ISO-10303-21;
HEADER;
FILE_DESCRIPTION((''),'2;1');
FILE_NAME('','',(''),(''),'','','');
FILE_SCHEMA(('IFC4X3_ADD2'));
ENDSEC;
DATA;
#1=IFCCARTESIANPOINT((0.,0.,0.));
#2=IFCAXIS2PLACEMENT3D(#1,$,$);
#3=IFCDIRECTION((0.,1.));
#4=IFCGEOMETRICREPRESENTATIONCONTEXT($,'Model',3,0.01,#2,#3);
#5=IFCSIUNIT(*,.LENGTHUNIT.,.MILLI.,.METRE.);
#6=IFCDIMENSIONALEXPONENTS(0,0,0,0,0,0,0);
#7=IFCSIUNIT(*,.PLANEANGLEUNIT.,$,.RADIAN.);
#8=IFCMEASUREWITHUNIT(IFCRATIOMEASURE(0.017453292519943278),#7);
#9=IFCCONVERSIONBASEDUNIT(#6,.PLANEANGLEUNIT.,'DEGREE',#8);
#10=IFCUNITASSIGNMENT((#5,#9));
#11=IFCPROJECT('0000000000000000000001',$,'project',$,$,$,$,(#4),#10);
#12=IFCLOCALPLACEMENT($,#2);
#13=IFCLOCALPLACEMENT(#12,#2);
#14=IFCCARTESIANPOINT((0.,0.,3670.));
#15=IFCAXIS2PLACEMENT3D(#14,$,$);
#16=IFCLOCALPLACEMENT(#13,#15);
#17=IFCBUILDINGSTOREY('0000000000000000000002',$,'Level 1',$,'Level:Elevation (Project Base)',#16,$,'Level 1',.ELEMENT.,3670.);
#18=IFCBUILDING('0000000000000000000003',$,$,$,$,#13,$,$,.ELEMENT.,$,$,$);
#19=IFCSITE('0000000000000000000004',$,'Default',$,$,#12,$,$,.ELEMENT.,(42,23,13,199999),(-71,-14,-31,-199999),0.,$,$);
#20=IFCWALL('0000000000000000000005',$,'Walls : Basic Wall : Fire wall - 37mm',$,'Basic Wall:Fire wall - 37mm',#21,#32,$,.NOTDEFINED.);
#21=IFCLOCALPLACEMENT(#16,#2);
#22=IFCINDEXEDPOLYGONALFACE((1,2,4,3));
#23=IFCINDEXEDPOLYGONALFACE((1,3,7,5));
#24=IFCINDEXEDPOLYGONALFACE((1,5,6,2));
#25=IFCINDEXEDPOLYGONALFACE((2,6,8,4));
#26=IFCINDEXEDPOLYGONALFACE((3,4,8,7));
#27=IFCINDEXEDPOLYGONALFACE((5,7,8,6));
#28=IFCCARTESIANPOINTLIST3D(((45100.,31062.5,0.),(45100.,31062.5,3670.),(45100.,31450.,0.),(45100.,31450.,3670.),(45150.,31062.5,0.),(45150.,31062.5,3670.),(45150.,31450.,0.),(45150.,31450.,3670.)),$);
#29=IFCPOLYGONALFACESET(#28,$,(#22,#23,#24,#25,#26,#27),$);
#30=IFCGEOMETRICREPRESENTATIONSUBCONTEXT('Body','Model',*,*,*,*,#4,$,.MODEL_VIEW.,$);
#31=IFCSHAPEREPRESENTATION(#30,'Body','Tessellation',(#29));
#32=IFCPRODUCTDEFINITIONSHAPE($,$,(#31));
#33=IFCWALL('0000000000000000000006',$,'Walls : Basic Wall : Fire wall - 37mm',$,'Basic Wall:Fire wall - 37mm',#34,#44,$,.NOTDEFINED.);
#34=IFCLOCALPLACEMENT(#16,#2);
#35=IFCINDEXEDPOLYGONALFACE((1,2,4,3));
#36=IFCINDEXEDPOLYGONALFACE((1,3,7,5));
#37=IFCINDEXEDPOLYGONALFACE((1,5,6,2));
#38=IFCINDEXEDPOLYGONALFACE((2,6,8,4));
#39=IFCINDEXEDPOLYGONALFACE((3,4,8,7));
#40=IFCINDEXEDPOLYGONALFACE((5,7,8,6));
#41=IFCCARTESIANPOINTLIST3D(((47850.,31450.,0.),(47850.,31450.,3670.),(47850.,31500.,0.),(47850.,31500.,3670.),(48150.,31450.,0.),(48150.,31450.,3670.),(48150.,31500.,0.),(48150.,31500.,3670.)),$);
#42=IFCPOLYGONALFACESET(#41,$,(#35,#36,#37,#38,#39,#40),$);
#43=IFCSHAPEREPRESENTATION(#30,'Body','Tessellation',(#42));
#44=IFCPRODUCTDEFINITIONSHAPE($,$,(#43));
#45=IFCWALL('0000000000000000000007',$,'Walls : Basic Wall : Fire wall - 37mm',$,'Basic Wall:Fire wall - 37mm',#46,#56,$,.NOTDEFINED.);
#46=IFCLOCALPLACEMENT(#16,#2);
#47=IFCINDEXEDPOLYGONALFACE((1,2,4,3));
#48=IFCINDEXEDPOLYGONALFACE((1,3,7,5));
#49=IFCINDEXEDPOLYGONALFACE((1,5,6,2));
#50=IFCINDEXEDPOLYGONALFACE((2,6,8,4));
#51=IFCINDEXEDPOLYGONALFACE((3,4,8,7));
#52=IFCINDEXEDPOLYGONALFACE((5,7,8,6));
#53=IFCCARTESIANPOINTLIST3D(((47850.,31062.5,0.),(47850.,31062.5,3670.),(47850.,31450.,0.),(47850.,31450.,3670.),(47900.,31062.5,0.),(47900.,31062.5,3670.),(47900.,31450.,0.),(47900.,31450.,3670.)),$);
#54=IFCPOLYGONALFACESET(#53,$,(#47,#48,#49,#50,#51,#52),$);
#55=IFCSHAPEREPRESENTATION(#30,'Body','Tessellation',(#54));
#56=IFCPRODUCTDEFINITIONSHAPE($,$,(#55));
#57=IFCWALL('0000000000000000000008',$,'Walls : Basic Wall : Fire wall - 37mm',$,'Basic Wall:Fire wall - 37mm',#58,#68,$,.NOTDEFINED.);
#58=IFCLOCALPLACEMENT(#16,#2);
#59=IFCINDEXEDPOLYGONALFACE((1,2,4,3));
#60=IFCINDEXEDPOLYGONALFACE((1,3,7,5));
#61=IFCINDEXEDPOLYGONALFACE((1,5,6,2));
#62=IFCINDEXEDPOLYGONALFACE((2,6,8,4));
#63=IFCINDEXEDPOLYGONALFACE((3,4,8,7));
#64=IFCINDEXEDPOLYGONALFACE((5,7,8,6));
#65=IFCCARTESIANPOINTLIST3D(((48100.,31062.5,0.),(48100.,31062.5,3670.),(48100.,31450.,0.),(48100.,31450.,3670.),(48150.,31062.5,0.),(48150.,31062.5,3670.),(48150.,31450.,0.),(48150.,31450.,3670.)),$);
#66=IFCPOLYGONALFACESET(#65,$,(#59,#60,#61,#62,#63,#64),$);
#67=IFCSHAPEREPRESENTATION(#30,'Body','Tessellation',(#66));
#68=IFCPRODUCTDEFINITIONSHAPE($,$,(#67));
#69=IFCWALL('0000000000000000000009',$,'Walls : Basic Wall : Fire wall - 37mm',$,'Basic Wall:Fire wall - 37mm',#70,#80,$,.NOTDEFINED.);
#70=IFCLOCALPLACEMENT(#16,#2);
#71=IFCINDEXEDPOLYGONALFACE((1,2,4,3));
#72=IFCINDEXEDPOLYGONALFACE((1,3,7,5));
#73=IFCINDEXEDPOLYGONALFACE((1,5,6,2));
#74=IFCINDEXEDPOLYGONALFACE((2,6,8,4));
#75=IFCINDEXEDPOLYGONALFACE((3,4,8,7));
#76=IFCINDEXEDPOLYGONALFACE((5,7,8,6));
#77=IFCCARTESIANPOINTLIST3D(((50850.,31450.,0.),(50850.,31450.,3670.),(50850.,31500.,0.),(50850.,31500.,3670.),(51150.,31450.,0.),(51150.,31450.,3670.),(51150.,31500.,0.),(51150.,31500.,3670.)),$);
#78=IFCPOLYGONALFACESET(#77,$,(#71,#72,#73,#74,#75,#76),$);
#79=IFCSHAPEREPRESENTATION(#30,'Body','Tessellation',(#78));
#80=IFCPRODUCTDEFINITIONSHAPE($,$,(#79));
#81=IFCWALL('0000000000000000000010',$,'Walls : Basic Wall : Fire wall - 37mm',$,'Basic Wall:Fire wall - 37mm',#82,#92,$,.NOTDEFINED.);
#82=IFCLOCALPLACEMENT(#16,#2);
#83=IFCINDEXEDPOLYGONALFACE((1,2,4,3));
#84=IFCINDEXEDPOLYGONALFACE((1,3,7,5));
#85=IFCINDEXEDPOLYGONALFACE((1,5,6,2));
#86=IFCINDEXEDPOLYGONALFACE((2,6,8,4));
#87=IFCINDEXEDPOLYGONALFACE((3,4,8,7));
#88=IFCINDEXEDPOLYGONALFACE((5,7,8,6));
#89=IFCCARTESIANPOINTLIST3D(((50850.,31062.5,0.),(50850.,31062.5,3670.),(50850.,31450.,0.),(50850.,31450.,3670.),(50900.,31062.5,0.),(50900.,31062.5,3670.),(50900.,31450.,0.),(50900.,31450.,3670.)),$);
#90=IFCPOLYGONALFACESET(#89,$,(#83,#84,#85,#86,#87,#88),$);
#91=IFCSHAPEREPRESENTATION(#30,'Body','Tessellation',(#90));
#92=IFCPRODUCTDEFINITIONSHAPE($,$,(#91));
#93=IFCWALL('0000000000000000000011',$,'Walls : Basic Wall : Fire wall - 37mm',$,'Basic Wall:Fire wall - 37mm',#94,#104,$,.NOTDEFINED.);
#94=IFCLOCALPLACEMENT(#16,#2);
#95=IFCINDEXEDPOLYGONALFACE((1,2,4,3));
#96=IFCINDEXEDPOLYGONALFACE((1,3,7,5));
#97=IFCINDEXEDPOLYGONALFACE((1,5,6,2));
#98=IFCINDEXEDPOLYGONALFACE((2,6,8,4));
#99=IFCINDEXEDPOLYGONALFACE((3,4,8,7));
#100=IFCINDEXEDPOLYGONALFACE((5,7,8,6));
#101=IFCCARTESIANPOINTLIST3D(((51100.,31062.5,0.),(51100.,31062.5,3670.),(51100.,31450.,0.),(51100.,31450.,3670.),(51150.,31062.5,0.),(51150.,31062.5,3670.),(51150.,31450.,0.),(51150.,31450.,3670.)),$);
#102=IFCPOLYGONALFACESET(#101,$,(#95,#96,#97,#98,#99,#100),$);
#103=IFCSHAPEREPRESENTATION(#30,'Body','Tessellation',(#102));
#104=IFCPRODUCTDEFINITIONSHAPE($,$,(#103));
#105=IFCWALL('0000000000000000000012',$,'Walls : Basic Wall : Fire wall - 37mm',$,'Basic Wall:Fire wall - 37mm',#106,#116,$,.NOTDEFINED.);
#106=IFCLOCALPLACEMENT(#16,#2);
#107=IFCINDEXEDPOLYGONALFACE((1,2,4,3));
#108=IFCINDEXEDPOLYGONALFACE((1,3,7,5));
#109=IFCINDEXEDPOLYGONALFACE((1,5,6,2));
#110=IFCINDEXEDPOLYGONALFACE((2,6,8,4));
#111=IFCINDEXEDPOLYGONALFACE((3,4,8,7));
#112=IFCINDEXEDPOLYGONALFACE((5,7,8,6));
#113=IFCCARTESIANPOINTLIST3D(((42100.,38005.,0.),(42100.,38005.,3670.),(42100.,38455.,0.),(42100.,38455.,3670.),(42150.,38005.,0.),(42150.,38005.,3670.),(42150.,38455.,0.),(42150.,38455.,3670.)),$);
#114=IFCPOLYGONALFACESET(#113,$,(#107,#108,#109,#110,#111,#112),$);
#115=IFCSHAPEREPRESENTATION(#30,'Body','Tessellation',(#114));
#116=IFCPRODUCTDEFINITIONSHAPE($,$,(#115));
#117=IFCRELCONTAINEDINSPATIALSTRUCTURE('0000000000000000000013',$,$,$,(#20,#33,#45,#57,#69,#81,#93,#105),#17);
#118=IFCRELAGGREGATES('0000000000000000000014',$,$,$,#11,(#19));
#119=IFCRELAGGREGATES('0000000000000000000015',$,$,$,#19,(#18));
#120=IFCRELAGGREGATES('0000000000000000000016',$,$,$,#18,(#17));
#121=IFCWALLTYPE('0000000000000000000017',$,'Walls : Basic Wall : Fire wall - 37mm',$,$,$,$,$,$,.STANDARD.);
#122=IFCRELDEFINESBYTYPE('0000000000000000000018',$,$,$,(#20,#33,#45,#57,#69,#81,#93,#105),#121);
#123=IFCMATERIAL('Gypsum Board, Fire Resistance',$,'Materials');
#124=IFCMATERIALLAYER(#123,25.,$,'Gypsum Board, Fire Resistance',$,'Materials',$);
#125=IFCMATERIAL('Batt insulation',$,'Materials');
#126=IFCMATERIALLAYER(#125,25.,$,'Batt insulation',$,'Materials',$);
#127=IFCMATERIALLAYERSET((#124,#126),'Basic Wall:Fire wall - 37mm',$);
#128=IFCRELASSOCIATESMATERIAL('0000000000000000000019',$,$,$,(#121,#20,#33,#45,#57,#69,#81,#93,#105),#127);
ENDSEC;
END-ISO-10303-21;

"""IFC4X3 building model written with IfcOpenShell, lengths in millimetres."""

from ifc_helpers import new_model, entity, si_unit, converted_unit, direction, frame, frame_2d, origin, place, context, subcontext, project, spatial, rectangle, extrude, material, layer, layer_set, type_object, element, save


model = new_model("IFC4X3")

# Units and contexts
model_context = context("Model", 3, precision=0.01, world=origin(), true_north=direction((0.0, 1.0)))
body_context = subcontext(model_context, "Body", "Model", "MODEL_VIEW")
ifc_project = project(units=[si_unit("LENGTHUNIT", "METRE", prefix="MILLI"), converted_unit("PLANEANGLEUNIT", "DEGREE", entity("IfcRatioMeasure", 0.017453292519943278), si_unit("PLANEANGLEUNIT", "RADIAN"), dimensions=[0, 0, 0, 0, 0, 0, 0])], contexts=[model_context])

# Site, building, storey
site_placement = place(None, origin())
site = spatial("IfcSite", under=ifc_project, at=site_placement, Name="Default", CompositionType="ELEMENT", RefLatitude=(42, 23, 13, 199999), RefLongitude=(-71, -14, -31, -199999), RefElevation=0.0)
building_placement = place(site_placement, origin())
building = spatial("IfcBuilding", under=site, at=building_placement, CompositionType="ELEMENT")
storey_placement = place(building_placement, frame((0.0, 0.0, 3670.0)))
storey = spatial("IfcBuildingStorey", under=building, at=storey_placement, Name="Level 1", ObjectType="Level:Elevation (Project Base)", LongName="Level 1", CompositionType="ELEMENT", Elevation=3670.0)

# Walls
ifc_material_1 = material(Name="Gypsum Board, Fire Resistance", Category="Materials")
ifc_layer_1 = layer(ifc_material_1, 25.0, Name="Gypsum Board, Fire Resistance", Category="Materials")
ifc_material_2 = material(Name="Batt insulation", Category="Materials")
ifc_layer_2 = layer(ifc_material_2, 25.0, Name="Batt insulation", Category="Materials")
ifc_layer_set = layer_set([ifc_layer_1, ifc_layer_2], Name="Basic Wall:Fire wall - 37mm")
wall_type = type_object("IfcWallType", Name="Walls : Basic Wall : Fire wall - 37mm", PredefinedType="STANDARD", material=ifc_layer_set)
for number, where, z_axis, x_axis, name in (
    (1, (45125.0, 31450.0, 0.0), (0.0, 0.0, 1.0), (0.0, -1.0, 0.0), "Walls : Basic Wall : Fire wall - 37mm"),
):
    element("IfcWall", number, at=place(storey_placement, frame(where, z_axis=z_axis, x_axis=x_axis)), inside=storey, type_object=wall_type, material=ifc_layer_set, Name=name, ObjectType="Basic Wall:Fire wall - 37mm", PredefinedType="NOTDEFINED", context=body_context, shape_type="SweptSolid", body=[
        extrude(rectangle(XDim=387.5, YDim=50.0, at=frame_2d((193.7, 0.0), x_axis=(-1.0, 0.0))), origin(), (0.0, 0.0, 1.0), 3670.0),
    ])
wall_1_placement = place(storey_placement, frame((47850.0, 31475.0, 0.0)))
element("IfcWall", 2, at=wall_1_placement, inside=storey, type_object=wall_type, material=ifc_layer_set, Name="Walls : Basic Wall : Fire wall - 37mm", ObjectType="Basic Wall:Fire wall - 37mm", PredefinedType="NOTDEFINED", context=body_context, shape_type="SweptSolid", body=[
    extrude(rectangle(XDim=300.0, YDim=50.0, at=frame_2d((150.0, 0.0), x_axis=(-1.0, 0.0))), origin(), (0.0, 0.0, 1.0), 3670.0),
])
wall_2_placement = place(storey_placement, frame((47875.0, 31450.0, 0.0), z_axis=(0.0, 0.0, 1.0), x_axis=(0.0, -1.0, 0.0)))
element("IfcWall", 3, at=wall_2_placement, inside=storey, type_object=wall_type, material=ifc_layer_set, Name="Walls : Basic Wall : Fire wall - 37mm", ObjectType="Basic Wall:Fire wall - 37mm", PredefinedType="NOTDEFINED", context=body_context, shape_type="SweptSolid", body=[
    extrude(rectangle(XDim=387.5, YDim=50.0, at=frame_2d((193.8, 0.0), x_axis=(-1.0, 0.0))), origin(), (0.0, 0.0, 1.0), 3670.0),
])
wall_3_placement = place(storey_placement, frame((48125.0, 31450.0, 0.0), z_axis=(0.0, 0.0, 1.0), x_axis=(0.0, -1.0, 0.0)))
element("IfcWall", 4, at=wall_3_placement, inside=storey, type_object=wall_type, material=ifc_layer_set, Name="Walls : Basic Wall : Fire wall - 37mm", ObjectType="Basic Wall:Fire wall - 37mm", PredefinedType="NOTDEFINED", context=body_context, shape_type="SweptSolid", body=[
    extrude(rectangle(XDim=387.5, YDim=50.0, at=frame_2d((193.8, 0.0), x_axis=(-1.0, 0.0))), origin(), (0.0, 0.0, 1.0), 3670.0),
])
wall_4_placement = place(storey_placement, frame((50850.0, 31475.0, 0.0)))
element("IfcWall", 5, at=wall_4_placement, inside=storey, type_object=wall_type, material=ifc_layer_set, Name="Walls : Basic Wall : Fire wall - 37mm", ObjectType="Basic Wall:Fire wall - 37mm", PredefinedType="NOTDEFINED", context=body_context, shape_type="SweptSolid", body=[
    extrude(rectangle(XDim=300.0, YDim=50.0, at=frame_2d((150.0, 0.0), x_axis=(-1.0, 0.0))), origin(), (0.0, 0.0, 1.0), 3670.0),
])
wall_5_placement = place(storey_placement, frame((50875.0, 31450.0, 0.0), z_axis=(0.0, 0.0, 1.0), x_axis=(0.0, -1.0, 0.0)))
element("IfcWall", 6, at=wall_5_placement, inside=storey, type_object=wall_type, material=ifc_layer_set, Name="Walls : Basic Wall : Fire wall - 37mm", ObjectType="Basic Wall:Fire wall - 37mm", PredefinedType="NOTDEFINED", context=body_context, shape_type="SweptSolid", body=[
    extrude(rectangle(XDim=387.5, YDim=50.0, at=frame_2d((193.8, 0.0), x_axis=(-1.0, 0.0))), origin(), (0.0, 0.0, 1.0), 3670.0),
])
wall_6_placement = place(storey_placement, frame((51125.0, 31450.0, 0.0), z_axis=(0.0, 0.0, 1.0), x_axis=(0.0, -1.0, 0.0)))
element("IfcWall", 7, at=wall_6_placement, inside=storey, type_object=wall_type, material=ifc_layer_set, Name="Walls : Basic Wall : Fire wall - 37mm", ObjectType="Basic Wall:Fire wall - 37mm", PredefinedType="NOTDEFINED", context=body_context, shape_type="SweptSolid", body=[
    extrude(rectangle(XDim=387.5, YDim=50.0, at=frame_2d((193.8, 0.0), x_axis=(-1.0, 0.0))), origin(), (0.0, 0.0, 1.0), 3670.0),
])
wall_7_placement = place(storey_placement, frame((42125.0, 38455.0, 0.0), z_axis=(0.0, 0.0, 1.0), x_axis=(0.0, -1.0, 0.0)))
element("IfcWall", 8, at=wall_7_placement, inside=storey, type_object=wall_type, material=ifc_layer_set, Name="Walls : Basic Wall : Fire wall - 37mm", ObjectType="Basic Wall:Fire wall - 37mm", PredefinedType="NOTDEFINED", context=body_context, shape_type="SweptSolid", body=[
    extrude(rectangle(XDim=450.0, YDim=50.0, at=frame_2d((225.0, 0.0), x_axis=(-1.0, 0.0))), origin(), (0.0, 0.0, 1.0), 3670.0),
])

save(model, "model.ifc")
